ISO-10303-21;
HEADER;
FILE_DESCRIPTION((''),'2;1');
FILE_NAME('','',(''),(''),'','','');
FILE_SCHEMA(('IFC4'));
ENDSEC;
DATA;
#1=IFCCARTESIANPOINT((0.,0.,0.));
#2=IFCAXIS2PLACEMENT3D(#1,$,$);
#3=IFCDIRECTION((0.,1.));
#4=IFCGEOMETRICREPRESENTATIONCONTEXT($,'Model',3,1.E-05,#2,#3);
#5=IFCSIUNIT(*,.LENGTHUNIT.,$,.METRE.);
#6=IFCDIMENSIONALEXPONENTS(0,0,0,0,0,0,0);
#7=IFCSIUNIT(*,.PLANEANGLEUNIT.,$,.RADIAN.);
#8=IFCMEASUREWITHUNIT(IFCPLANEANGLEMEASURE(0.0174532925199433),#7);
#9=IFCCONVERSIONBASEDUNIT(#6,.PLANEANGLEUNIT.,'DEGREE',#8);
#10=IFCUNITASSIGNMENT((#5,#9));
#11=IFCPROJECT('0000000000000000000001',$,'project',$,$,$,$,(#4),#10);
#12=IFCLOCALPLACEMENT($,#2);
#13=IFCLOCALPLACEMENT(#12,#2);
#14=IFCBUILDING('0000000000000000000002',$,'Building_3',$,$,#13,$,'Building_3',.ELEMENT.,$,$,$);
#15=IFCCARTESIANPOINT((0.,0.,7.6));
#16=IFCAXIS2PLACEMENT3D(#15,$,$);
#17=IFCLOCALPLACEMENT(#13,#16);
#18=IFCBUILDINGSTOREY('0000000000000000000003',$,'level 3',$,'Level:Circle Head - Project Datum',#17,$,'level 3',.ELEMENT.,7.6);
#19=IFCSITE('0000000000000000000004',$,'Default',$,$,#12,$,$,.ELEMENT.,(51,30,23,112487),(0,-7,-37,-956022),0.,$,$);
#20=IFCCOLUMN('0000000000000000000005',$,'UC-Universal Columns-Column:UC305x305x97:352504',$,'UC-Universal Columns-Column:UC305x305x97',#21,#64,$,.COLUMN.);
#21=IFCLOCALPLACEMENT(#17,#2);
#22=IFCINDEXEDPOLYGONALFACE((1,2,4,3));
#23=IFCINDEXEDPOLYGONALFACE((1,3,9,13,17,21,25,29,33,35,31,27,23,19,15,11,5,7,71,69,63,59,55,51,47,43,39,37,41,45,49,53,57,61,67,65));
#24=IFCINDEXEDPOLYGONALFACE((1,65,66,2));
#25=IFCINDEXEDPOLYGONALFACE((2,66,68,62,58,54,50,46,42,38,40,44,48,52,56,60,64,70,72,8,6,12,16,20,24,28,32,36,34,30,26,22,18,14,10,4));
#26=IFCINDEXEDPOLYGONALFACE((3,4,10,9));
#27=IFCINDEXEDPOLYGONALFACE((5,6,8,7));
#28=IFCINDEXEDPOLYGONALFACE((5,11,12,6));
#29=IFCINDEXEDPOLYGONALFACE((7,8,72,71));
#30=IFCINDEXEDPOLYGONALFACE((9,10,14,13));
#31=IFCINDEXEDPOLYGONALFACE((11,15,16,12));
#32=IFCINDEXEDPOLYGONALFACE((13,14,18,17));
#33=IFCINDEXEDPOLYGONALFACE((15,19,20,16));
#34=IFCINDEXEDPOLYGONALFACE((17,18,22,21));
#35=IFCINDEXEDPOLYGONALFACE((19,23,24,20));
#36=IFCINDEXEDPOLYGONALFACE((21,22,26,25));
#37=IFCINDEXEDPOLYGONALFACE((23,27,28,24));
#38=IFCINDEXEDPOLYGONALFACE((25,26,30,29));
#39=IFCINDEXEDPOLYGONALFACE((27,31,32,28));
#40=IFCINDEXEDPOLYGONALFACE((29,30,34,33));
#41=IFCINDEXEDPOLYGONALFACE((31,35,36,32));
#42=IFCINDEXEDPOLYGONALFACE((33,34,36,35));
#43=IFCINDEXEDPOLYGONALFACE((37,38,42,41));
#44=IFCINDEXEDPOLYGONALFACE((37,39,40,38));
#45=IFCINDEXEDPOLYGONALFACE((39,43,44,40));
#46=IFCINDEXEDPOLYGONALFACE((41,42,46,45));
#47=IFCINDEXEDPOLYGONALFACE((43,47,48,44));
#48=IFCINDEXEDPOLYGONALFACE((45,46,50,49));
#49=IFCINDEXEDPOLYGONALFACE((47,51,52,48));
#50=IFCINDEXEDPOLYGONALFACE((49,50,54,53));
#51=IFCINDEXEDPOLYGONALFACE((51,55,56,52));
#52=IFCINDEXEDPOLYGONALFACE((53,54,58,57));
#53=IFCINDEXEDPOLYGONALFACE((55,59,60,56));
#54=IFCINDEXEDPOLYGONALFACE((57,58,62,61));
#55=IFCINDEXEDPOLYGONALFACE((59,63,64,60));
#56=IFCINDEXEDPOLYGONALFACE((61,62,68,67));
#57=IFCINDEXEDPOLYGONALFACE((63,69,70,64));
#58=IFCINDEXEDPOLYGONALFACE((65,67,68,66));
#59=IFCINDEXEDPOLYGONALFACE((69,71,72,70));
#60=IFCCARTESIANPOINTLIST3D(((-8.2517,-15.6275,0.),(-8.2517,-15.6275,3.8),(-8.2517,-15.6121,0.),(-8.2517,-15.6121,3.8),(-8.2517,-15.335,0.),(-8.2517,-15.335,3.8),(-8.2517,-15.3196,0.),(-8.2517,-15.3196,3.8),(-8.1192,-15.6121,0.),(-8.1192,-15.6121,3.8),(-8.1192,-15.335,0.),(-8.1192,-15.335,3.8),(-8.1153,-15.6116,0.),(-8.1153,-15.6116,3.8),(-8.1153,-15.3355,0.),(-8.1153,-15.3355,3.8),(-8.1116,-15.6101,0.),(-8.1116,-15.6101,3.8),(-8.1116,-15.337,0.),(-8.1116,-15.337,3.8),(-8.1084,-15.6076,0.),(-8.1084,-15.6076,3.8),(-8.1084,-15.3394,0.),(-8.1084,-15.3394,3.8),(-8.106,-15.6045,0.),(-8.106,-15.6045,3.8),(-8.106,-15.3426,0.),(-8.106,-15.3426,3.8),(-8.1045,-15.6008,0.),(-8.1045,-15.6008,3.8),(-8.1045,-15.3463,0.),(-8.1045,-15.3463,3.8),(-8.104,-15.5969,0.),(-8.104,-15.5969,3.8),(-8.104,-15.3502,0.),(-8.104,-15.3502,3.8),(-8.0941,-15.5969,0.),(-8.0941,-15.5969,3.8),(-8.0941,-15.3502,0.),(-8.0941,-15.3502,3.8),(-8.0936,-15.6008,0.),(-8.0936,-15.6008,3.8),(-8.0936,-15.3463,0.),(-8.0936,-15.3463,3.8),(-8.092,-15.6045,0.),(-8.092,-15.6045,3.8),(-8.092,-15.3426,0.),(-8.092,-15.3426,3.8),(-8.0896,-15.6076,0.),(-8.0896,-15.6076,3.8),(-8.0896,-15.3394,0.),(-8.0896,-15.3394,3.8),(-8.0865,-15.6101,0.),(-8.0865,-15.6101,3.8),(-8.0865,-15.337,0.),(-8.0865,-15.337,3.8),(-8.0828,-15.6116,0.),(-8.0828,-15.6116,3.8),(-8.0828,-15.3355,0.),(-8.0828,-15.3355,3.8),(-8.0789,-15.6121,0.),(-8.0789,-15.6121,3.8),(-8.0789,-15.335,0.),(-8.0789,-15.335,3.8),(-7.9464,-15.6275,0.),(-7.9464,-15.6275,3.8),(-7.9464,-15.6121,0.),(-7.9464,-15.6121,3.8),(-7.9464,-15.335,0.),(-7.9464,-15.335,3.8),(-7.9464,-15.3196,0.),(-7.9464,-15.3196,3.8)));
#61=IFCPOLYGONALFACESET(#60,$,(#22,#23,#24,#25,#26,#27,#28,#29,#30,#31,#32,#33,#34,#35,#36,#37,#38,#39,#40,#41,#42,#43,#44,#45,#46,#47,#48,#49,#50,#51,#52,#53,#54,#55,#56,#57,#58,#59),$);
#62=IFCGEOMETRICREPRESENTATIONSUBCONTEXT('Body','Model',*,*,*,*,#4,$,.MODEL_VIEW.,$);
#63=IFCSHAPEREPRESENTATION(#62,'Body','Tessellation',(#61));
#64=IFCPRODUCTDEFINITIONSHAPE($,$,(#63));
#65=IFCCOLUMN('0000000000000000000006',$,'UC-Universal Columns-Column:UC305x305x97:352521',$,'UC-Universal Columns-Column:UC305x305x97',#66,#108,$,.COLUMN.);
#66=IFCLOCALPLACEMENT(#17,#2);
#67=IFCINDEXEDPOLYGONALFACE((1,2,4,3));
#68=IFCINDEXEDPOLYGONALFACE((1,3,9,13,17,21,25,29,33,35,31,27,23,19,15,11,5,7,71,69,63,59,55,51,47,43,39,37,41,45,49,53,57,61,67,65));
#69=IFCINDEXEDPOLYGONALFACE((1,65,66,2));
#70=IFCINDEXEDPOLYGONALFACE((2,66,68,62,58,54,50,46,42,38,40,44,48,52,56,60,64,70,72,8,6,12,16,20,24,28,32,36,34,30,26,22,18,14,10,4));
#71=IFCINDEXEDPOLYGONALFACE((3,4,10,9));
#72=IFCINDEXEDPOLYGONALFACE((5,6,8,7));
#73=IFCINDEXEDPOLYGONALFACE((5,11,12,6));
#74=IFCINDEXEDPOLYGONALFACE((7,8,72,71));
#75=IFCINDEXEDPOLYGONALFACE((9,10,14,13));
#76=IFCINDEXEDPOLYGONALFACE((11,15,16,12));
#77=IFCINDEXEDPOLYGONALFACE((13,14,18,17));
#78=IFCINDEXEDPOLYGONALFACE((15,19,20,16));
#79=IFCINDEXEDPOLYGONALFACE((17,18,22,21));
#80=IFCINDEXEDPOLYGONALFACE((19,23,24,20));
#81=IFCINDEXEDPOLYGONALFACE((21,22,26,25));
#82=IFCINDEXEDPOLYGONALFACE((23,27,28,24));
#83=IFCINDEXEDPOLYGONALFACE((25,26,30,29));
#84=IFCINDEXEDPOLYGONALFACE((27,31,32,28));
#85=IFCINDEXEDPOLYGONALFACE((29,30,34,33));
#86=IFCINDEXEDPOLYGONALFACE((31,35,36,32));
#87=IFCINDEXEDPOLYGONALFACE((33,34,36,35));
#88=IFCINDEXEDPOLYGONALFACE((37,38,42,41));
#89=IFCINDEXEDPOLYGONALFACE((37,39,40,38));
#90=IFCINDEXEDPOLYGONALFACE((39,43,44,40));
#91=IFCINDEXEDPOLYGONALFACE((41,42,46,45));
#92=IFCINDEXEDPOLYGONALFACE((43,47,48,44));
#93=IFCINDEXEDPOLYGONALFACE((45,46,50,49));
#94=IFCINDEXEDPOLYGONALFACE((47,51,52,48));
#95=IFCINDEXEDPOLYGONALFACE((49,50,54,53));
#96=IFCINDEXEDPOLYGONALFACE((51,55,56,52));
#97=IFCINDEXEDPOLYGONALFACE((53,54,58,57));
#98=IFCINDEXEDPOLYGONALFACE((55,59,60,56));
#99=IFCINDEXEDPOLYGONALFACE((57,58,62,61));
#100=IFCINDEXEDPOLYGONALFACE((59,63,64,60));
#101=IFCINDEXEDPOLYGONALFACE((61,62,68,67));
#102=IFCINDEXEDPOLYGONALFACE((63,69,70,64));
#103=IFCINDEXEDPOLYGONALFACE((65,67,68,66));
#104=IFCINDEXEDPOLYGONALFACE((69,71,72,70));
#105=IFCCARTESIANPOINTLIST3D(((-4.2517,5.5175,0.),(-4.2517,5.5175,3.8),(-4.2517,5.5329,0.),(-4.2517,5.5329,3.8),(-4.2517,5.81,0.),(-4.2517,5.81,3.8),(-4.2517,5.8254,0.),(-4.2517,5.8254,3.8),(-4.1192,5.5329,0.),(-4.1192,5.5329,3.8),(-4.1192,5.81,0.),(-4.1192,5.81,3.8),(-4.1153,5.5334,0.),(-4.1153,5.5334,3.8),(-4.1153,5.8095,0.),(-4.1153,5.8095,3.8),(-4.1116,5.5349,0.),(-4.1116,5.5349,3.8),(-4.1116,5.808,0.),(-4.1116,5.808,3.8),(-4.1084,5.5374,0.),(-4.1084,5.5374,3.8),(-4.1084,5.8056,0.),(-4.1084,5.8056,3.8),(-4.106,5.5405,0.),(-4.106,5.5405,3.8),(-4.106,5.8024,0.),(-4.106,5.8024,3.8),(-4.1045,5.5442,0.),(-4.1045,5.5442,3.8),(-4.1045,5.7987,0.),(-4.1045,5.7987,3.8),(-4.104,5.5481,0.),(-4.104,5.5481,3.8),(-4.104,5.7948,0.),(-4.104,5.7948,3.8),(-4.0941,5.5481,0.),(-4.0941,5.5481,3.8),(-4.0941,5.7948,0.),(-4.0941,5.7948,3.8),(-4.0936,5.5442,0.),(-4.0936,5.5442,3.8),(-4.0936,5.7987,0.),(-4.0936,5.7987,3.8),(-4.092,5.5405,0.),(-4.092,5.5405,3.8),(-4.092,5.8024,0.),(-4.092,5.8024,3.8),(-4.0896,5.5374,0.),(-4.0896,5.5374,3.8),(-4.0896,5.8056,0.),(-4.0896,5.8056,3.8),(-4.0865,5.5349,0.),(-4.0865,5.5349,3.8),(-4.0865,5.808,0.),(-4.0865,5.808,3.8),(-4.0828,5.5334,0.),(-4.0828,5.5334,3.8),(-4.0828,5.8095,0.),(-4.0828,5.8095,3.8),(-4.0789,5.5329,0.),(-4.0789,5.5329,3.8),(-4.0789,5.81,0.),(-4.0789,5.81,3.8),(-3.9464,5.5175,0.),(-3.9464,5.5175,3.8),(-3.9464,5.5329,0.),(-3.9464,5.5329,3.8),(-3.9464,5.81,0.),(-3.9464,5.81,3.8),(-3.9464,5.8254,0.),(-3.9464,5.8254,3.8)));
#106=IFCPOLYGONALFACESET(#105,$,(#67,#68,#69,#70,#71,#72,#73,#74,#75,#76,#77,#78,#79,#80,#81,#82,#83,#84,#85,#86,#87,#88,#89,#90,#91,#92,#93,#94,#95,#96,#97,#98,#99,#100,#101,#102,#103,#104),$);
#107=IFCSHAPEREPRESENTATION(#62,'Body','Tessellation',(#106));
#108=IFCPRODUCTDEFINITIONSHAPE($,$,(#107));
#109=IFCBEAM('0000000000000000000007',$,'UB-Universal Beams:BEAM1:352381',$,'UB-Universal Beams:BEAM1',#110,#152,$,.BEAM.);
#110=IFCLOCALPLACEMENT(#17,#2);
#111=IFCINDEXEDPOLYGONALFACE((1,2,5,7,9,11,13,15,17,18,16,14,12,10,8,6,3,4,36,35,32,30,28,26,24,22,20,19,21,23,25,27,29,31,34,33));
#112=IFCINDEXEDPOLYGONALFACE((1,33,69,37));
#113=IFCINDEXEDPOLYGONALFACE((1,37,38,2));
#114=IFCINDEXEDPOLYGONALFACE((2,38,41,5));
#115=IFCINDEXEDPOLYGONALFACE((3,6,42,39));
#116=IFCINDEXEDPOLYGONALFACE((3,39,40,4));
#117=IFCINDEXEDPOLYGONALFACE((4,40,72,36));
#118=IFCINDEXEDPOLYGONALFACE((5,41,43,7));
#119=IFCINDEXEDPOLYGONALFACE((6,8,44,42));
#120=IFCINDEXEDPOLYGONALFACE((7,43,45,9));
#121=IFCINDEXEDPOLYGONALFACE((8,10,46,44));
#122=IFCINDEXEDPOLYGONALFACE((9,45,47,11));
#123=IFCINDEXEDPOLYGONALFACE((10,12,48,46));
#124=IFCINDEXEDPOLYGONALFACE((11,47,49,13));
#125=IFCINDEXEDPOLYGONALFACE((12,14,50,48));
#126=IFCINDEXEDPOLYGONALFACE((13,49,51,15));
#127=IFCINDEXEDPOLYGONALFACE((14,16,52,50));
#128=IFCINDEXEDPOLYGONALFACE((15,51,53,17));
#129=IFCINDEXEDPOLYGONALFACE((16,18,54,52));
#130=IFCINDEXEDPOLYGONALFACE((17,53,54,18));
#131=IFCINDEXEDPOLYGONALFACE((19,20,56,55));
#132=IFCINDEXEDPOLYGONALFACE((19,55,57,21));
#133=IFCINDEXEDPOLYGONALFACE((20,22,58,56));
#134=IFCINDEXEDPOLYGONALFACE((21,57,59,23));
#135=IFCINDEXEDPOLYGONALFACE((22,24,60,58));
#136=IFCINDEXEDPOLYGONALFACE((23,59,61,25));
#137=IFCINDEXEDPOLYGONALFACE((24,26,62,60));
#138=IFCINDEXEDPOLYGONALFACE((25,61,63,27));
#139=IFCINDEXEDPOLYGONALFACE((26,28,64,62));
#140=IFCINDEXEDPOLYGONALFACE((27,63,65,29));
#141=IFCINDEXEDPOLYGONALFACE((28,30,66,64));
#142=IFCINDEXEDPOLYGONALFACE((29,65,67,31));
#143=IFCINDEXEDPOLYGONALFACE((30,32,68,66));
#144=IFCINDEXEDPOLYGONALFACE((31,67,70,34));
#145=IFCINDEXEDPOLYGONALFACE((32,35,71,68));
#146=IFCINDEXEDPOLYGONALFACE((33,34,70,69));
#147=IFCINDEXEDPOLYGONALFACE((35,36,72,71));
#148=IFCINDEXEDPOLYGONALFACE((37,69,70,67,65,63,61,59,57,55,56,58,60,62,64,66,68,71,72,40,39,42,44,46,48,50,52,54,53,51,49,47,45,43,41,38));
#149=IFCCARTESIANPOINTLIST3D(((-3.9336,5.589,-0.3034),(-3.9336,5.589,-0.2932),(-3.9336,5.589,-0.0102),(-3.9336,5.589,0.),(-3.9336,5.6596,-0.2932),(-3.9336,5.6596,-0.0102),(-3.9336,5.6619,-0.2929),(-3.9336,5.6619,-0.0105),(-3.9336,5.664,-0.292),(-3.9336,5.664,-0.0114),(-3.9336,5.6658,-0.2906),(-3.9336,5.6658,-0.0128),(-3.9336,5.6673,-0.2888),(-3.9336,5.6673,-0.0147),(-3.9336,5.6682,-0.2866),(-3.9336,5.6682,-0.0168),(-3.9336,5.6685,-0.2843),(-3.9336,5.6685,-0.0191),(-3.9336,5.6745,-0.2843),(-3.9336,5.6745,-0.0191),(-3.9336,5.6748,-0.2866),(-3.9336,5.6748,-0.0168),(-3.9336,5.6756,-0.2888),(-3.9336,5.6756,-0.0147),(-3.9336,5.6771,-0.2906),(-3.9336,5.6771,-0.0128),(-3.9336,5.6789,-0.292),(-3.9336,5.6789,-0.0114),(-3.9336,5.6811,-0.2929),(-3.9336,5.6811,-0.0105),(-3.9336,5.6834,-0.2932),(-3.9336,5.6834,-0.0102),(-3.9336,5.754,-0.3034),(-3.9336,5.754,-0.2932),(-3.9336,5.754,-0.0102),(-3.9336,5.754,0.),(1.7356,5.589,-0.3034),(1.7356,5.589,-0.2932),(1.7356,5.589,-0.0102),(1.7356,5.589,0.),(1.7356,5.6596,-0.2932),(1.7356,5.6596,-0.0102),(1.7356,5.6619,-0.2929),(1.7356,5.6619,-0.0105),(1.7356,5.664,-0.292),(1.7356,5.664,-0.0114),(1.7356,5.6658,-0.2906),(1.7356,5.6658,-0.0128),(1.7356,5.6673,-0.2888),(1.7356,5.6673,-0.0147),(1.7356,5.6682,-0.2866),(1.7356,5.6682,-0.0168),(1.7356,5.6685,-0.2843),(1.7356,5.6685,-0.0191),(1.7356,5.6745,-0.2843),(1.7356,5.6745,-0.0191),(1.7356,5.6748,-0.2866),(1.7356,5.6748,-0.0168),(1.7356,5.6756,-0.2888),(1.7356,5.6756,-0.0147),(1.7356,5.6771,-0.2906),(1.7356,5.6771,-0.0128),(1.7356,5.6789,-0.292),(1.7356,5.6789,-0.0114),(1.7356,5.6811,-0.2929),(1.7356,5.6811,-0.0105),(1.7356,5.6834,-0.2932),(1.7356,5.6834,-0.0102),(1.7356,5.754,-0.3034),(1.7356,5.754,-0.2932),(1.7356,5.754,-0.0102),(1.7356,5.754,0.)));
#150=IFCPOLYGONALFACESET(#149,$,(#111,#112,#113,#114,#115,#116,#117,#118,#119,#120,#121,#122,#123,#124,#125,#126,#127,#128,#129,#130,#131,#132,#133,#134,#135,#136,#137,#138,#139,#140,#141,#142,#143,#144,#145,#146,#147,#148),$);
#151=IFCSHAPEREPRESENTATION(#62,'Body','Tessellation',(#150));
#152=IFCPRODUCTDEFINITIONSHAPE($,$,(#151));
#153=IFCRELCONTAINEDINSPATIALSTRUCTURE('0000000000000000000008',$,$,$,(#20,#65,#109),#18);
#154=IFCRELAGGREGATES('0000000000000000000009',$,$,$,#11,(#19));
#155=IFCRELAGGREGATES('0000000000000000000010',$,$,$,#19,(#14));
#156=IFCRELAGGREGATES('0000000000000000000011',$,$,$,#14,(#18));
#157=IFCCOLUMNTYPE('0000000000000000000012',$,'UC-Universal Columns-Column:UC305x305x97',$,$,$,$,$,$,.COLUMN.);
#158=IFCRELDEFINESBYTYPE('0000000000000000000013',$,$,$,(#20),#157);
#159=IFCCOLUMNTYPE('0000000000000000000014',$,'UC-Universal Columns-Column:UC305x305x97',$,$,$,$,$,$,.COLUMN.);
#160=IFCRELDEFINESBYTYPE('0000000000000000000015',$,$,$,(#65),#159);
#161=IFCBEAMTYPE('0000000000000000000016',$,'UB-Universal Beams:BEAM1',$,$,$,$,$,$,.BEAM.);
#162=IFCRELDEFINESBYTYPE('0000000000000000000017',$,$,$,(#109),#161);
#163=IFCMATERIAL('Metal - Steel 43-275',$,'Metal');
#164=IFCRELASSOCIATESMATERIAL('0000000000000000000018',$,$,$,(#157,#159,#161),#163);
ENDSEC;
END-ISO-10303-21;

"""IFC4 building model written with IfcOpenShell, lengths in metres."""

from ifc_helpers import new_model, entity, si_unit, converted_unit, direction, frame, frame_2d, origin, place, context, subcontext, project, spatial, polyline, circle_curve, parameter, trimmed, segment, composite_curve, i_section, outline, extrude, source, transform, mapped, material, material_profile, profile_set, type_object, type_shapes, element, save


model = new_model("IFC4")

# Units and contexts
model_context = context("Model", 3, precision=1e-05, world=origin(), true_north=direction((0.0, 1.0)))
body_context = subcontext(model_context, "Body", "Model", "MODEL_VIEW")
ifc_project = project(units=[si_unit("LENGTHUNIT", "METRE"), converted_unit("PLANEANGLEUNIT", "DEGREE", entity("IfcPlaneAngleMeasure", 0.0174532925199433), si_unit("PLANEANGLEUNIT", "RADIAN"), dimensions=[0, 0, 0, 0, 0, 0, 0])], contexts=[model_context])

# Site, building, storey
site_placement = place(None, origin())
site = spatial("IfcSite", under=ifc_project, at=site_placement, Name="Default", CompositionType="ELEMENT", RefLatitude=(51, 30, 23, 112487), RefLongitude=(0, -7, -37, -956022), RefElevation=0.0)
building_placement = place(site_placement, origin())
building = spatial("IfcBuilding", under=site, at=building_placement, Name="Building_3", LongName="Building_3", CompositionType="ELEMENT")
storey_placement = place(building_placement, frame((0.0, 0.0, 7.6)))
storey = spatial("IfcBuildingStorey", under=building, at=storey_placement, Name="level 3", ObjectType="Level:Circle Head - Project Datum", LongName="level 3", CompositionType="ELEMENT", Elevation=7.6)

# Columns
ifc_material_1 = material(Name="Metal - Steel 43-275", Category="Metal")
ifc_material_profile_1 = material_profile(ifc_material_1, i_section(OverallWidth=0.3053, OverallDepth=0.3079, WebThickness=0.0099, FlangeThickness=0.0154, FilletRadius=0.0152, at=frame_2d((0.0, 0.0), x_axis=(1.0, 0.0))), Name="UC305x305x97")
ifc_profile_set_1 = profile_set([ifc_material_profile_1], Name="UC305x305x97")
column_type_1 = type_object("IfcColumnType", Name="UC-Universal Columns-Column:UC305x305x97", PredefinedType="COLUMN", material=ifc_profile_set_1)
shared_shape_1 = source(origin(), body_context, "Body", "SweptSolid", [
    extrude(i_section(OverallWidth=0.3053, OverallDepth=0.3079, WebThickness=0.0099, FlangeThickness=0.0154, FilletRadius=0.0152, at=frame_2d((0.0, 0.0), x_axis=(1.0, 0.0))), frame((-8.099, -15.4735, 7.6), z_axis=(0.0, 0.0, 1.0), x_axis=(-1.0, 0.0, 0.0)), (0.0, 0.0, 1.0), 3.8),
])
type_shapes(column_type_1, [shared_shape_1])
column_1_placement = place(storey_placement, frame((0.0, 0.0, -7.6)))
element("IfcColumn", 1, at=column_1_placement, inside=storey, type_object=column_type_1, Name="UC-Universal Columns-Column:UC305x305x97:352504", ObjectType="UC-Universal Columns-Column:UC305x305x97", PredefinedType="COLUMN", context=body_context, shape_type="MappedRepresentation", body=[
    mapped(shared_shape_1, transform((0.0, 0.0, 0.0), scale=1.0)),
])
column_type_2 = type_object("IfcColumnType", Name="UC-Universal Columns-Column:UC305x305x97", PredefinedType="COLUMN", material=ifc_profile_set_1)
shared_shape_2 = source(origin(), body_context, "Body", "SweptSolid", [
    extrude(i_section(OverallWidth=0.3053, OverallDepth=0.3079, WebThickness=0.0099, FlangeThickness=0.0154, FilletRadius=0.0152, at=frame_2d((0.0, 0.0), x_axis=(1.0, 0.0))), frame((-4.099, 5.6715, 7.6), z_axis=(0.0, 0.0, 1.0), x_axis=(-1.0, 0.0, 0.0)), (0.0, 0.0, 1.0), 3.8),
])
type_shapes(column_type_2, [shared_shape_2])
column_2_placement = place(storey_placement, frame((0.0, 0.0, -7.6)))
element("IfcColumn", 2, at=column_2_placement, inside=storey, type_object=column_type_2, Name="UC-Universal Columns-Column:UC305x305x97:352521", ObjectType="UC-Universal Columns-Column:UC305x305x97", PredefinedType="COLUMN", context=body_context, shape_type="MappedRepresentation", body=[
    mapped(shared_shape_2, transform((0.0, 0.0, 0.0), scale=1.0)),
])

# Beam
ifc_material_profile_2 = material_profile(ifc_material_1, outline(composite_curve([segment(polyline([(-0.0825, -0.1415), (-0.0825, -0.1517)]), True, "CONTINUOUS"), segment(polyline([(-0.0825, -0.1517), (0.0825, -0.1517)]), True, "CONTINUOUS"), segment(polyline([(0.0825, -0.1517), (0.0825, -0.1415)]), True, "CONTINUOUS"), segment(polyline([(0.0825, -0.1415), (0.0119, -0.1415)]), True, "CONTINUOUS"), segment(trimmed(circle_curve(frame_2d((0.0119, -0.1326), x_axis=(1.0, 0.0)), 0.0089), [parameter(180.0)], [parameter(270.0)], True, "PARAMETER"), False, "CONTINUOUS"), segment(polyline([(0.003, -0.1326), (0.003, 0.1326)]), True, "CONTINUOUS"), segment(trimmed(circle_curve(frame_2d((0.0119, 0.1326), x_axis=(1.0, 0.0)), 0.0089), [parameter(90.0)], [parameter(180.0)], True, "PARAMETER"), False, "CONTINUOUS"), segment(polyline([(0.0119, 0.1415), (0.0825, 0.1415)]), True, "CONTINUOUS"), segment(polyline([(0.0825, 0.1415), (0.0825, 0.1517)]), True, "CONTINUOUS"), segment(polyline([(0.0825, 0.1517), (-0.0825, 0.1517)]), True, "CONTINUOUS"), segment(polyline([(-0.0825, 0.1517), (-0.0825, 0.1415)]), True, "CONTINUOUS"), segment(polyline([(-0.0825, 0.1415), (-0.0119, 0.1415)]), True, "CONTINUOUS"), segment(trimmed(circle_curve(frame_2d((-0.0119, 0.1326), x_axis=(1.0, 0.0)), 0.0089), [parameter(360.0)], [parameter(90.0)], True, "PARAMETER"), False, "CONTINUOUS"), segment(polyline([(-0.003, 0.1326), (-0.003, -0.1326)]), True, "CONTINUOUS"), segment(trimmed(circle_curve(frame_2d((-0.0119, -0.1326), x_axis=(1.0, 0.0)), 0.0089), [parameter(270.0)], [parameter(360.0)], True, "PARAMETER"), False, "CONTINUOUS"), segment(polyline([(-0.0119, -0.1415), (-0.0825, -0.1415)]), True, "CONTINUOUS")], self_intersect=False)), Name="BEAM1")
ifc_profile_set_2 = profile_set([ifc_material_profile_2], Name="BEAM1")
beam_type_1 = type_object("IfcBeamType", Name="UB-Universal Beams:BEAM1", PredefinedType="BEAM", material=ifc_profile_set_2)
shared_shape_3 = source(origin(), body_context, "Body", "SweptSolid", [
    extrude(outline(composite_curve([segment(polyline([(-0.0825, -0.1415), (-0.0825, -0.1517)]), True, "CONTINUOUS"), segment(polyline([(-0.0825, -0.1517), (0.0825, -0.1517)]), True, "CONTINUOUS"), segment(polyline([(0.0825, -0.1517), (0.0825, -0.1415)]), True, "CONTINUOUS"), segment(polyline([(0.0825, -0.1415), (0.0119, -0.1415)]), True, "CONTINUOUS"), segment(trimmed(circle_curve(frame_2d((0.0119, -0.1326), x_axis=(0.0, -1.0)), 0.0089), [parameter(270.0)], [parameter(360.0)], True, "PARAMETER"), False, "CONTINUOUS"), segment(polyline([(0.003, -0.1326), (0.003, 0.1326)]), True, "CONTINUOUS"), segment(trimmed(circle_curve(frame_2d((0.0119, 0.1326), x_axis=(-1.0, 0.0)), 0.0089), [parameter(270.0)], [parameter(360.0)], True, "PARAMETER"), False, "CONTINUOUS"), segment(polyline([(0.0119, 0.1415), (0.0825, 0.1415)]), True, "CONTINUOUS"), segment(polyline([(0.0825, 0.1415), (0.0825, 0.1517)]), True, "CONTINUOUS"), segment(polyline([(0.0825, 0.1517), (-0.0825, 0.1517)]), True, "CONTINUOUS"), segment(polyline([(-0.0825, 0.1517), (-0.0825, 0.1415)]), True, "CONTINUOUS"), segment(polyline([(-0.0825, 0.1415), (-0.0119, 0.1415)]), True, "CONTINUOUS"), segment(trimmed(circle_curve(frame_2d((-0.0119, 0.1326), x_axis=(0.0, 1.0)), 0.0089), [parameter(270.0)], [parameter(360.0)], True, "PARAMETER"), False, "CONTINUOUS"), segment(polyline([(-0.003, 0.1326), (-0.003, -0.1326)]), True, "CONTINUOUS"), segment(trimmed(circle_curve(frame_2d((-0.0119, -0.1326), x_axis=(1.0, 0.0)), 0.0089), [parameter(270.0)], [parameter(0.0)], True, "PARAMETER"), False, "CONTINUOUS"), segment(polyline([(-0.0119, -0.1415), (-0.0825, -0.1415)]), True, "CONTINUOUS")], self_intersect=False)), frame((-2.8346, 0.0, 0.0), z_axis=(-1.0, 0.0, 0.0), x_axis=(0.0, -1.0, 0.0)), (0.0, 0.0, -1.0), 5.6692),
])
type_shapes(beam_type_1, [shared_shape_3])
beam_1_placement = place(storey_placement, frame((-1.099, 5.6715, -0.1517), z_axis=(0.0, 0.0, 1.0), x_axis=(-1.0, 0.0, 0.0)))
element("IfcBeam", 3, at=beam_1_placement, inside=storey, type_object=beam_type_1, Name="UB-Universal Beams:BEAM1:352381", ObjectType="UB-Universal Beams:BEAM1", PredefinedType="BEAM", context=body_context, shape_type="MappedRepresentation", body=[
    mapped(shared_shape_3, transform((0.0, 0.0, 0.0), scale=1.0)),
])

save(model, "model.ifc")
